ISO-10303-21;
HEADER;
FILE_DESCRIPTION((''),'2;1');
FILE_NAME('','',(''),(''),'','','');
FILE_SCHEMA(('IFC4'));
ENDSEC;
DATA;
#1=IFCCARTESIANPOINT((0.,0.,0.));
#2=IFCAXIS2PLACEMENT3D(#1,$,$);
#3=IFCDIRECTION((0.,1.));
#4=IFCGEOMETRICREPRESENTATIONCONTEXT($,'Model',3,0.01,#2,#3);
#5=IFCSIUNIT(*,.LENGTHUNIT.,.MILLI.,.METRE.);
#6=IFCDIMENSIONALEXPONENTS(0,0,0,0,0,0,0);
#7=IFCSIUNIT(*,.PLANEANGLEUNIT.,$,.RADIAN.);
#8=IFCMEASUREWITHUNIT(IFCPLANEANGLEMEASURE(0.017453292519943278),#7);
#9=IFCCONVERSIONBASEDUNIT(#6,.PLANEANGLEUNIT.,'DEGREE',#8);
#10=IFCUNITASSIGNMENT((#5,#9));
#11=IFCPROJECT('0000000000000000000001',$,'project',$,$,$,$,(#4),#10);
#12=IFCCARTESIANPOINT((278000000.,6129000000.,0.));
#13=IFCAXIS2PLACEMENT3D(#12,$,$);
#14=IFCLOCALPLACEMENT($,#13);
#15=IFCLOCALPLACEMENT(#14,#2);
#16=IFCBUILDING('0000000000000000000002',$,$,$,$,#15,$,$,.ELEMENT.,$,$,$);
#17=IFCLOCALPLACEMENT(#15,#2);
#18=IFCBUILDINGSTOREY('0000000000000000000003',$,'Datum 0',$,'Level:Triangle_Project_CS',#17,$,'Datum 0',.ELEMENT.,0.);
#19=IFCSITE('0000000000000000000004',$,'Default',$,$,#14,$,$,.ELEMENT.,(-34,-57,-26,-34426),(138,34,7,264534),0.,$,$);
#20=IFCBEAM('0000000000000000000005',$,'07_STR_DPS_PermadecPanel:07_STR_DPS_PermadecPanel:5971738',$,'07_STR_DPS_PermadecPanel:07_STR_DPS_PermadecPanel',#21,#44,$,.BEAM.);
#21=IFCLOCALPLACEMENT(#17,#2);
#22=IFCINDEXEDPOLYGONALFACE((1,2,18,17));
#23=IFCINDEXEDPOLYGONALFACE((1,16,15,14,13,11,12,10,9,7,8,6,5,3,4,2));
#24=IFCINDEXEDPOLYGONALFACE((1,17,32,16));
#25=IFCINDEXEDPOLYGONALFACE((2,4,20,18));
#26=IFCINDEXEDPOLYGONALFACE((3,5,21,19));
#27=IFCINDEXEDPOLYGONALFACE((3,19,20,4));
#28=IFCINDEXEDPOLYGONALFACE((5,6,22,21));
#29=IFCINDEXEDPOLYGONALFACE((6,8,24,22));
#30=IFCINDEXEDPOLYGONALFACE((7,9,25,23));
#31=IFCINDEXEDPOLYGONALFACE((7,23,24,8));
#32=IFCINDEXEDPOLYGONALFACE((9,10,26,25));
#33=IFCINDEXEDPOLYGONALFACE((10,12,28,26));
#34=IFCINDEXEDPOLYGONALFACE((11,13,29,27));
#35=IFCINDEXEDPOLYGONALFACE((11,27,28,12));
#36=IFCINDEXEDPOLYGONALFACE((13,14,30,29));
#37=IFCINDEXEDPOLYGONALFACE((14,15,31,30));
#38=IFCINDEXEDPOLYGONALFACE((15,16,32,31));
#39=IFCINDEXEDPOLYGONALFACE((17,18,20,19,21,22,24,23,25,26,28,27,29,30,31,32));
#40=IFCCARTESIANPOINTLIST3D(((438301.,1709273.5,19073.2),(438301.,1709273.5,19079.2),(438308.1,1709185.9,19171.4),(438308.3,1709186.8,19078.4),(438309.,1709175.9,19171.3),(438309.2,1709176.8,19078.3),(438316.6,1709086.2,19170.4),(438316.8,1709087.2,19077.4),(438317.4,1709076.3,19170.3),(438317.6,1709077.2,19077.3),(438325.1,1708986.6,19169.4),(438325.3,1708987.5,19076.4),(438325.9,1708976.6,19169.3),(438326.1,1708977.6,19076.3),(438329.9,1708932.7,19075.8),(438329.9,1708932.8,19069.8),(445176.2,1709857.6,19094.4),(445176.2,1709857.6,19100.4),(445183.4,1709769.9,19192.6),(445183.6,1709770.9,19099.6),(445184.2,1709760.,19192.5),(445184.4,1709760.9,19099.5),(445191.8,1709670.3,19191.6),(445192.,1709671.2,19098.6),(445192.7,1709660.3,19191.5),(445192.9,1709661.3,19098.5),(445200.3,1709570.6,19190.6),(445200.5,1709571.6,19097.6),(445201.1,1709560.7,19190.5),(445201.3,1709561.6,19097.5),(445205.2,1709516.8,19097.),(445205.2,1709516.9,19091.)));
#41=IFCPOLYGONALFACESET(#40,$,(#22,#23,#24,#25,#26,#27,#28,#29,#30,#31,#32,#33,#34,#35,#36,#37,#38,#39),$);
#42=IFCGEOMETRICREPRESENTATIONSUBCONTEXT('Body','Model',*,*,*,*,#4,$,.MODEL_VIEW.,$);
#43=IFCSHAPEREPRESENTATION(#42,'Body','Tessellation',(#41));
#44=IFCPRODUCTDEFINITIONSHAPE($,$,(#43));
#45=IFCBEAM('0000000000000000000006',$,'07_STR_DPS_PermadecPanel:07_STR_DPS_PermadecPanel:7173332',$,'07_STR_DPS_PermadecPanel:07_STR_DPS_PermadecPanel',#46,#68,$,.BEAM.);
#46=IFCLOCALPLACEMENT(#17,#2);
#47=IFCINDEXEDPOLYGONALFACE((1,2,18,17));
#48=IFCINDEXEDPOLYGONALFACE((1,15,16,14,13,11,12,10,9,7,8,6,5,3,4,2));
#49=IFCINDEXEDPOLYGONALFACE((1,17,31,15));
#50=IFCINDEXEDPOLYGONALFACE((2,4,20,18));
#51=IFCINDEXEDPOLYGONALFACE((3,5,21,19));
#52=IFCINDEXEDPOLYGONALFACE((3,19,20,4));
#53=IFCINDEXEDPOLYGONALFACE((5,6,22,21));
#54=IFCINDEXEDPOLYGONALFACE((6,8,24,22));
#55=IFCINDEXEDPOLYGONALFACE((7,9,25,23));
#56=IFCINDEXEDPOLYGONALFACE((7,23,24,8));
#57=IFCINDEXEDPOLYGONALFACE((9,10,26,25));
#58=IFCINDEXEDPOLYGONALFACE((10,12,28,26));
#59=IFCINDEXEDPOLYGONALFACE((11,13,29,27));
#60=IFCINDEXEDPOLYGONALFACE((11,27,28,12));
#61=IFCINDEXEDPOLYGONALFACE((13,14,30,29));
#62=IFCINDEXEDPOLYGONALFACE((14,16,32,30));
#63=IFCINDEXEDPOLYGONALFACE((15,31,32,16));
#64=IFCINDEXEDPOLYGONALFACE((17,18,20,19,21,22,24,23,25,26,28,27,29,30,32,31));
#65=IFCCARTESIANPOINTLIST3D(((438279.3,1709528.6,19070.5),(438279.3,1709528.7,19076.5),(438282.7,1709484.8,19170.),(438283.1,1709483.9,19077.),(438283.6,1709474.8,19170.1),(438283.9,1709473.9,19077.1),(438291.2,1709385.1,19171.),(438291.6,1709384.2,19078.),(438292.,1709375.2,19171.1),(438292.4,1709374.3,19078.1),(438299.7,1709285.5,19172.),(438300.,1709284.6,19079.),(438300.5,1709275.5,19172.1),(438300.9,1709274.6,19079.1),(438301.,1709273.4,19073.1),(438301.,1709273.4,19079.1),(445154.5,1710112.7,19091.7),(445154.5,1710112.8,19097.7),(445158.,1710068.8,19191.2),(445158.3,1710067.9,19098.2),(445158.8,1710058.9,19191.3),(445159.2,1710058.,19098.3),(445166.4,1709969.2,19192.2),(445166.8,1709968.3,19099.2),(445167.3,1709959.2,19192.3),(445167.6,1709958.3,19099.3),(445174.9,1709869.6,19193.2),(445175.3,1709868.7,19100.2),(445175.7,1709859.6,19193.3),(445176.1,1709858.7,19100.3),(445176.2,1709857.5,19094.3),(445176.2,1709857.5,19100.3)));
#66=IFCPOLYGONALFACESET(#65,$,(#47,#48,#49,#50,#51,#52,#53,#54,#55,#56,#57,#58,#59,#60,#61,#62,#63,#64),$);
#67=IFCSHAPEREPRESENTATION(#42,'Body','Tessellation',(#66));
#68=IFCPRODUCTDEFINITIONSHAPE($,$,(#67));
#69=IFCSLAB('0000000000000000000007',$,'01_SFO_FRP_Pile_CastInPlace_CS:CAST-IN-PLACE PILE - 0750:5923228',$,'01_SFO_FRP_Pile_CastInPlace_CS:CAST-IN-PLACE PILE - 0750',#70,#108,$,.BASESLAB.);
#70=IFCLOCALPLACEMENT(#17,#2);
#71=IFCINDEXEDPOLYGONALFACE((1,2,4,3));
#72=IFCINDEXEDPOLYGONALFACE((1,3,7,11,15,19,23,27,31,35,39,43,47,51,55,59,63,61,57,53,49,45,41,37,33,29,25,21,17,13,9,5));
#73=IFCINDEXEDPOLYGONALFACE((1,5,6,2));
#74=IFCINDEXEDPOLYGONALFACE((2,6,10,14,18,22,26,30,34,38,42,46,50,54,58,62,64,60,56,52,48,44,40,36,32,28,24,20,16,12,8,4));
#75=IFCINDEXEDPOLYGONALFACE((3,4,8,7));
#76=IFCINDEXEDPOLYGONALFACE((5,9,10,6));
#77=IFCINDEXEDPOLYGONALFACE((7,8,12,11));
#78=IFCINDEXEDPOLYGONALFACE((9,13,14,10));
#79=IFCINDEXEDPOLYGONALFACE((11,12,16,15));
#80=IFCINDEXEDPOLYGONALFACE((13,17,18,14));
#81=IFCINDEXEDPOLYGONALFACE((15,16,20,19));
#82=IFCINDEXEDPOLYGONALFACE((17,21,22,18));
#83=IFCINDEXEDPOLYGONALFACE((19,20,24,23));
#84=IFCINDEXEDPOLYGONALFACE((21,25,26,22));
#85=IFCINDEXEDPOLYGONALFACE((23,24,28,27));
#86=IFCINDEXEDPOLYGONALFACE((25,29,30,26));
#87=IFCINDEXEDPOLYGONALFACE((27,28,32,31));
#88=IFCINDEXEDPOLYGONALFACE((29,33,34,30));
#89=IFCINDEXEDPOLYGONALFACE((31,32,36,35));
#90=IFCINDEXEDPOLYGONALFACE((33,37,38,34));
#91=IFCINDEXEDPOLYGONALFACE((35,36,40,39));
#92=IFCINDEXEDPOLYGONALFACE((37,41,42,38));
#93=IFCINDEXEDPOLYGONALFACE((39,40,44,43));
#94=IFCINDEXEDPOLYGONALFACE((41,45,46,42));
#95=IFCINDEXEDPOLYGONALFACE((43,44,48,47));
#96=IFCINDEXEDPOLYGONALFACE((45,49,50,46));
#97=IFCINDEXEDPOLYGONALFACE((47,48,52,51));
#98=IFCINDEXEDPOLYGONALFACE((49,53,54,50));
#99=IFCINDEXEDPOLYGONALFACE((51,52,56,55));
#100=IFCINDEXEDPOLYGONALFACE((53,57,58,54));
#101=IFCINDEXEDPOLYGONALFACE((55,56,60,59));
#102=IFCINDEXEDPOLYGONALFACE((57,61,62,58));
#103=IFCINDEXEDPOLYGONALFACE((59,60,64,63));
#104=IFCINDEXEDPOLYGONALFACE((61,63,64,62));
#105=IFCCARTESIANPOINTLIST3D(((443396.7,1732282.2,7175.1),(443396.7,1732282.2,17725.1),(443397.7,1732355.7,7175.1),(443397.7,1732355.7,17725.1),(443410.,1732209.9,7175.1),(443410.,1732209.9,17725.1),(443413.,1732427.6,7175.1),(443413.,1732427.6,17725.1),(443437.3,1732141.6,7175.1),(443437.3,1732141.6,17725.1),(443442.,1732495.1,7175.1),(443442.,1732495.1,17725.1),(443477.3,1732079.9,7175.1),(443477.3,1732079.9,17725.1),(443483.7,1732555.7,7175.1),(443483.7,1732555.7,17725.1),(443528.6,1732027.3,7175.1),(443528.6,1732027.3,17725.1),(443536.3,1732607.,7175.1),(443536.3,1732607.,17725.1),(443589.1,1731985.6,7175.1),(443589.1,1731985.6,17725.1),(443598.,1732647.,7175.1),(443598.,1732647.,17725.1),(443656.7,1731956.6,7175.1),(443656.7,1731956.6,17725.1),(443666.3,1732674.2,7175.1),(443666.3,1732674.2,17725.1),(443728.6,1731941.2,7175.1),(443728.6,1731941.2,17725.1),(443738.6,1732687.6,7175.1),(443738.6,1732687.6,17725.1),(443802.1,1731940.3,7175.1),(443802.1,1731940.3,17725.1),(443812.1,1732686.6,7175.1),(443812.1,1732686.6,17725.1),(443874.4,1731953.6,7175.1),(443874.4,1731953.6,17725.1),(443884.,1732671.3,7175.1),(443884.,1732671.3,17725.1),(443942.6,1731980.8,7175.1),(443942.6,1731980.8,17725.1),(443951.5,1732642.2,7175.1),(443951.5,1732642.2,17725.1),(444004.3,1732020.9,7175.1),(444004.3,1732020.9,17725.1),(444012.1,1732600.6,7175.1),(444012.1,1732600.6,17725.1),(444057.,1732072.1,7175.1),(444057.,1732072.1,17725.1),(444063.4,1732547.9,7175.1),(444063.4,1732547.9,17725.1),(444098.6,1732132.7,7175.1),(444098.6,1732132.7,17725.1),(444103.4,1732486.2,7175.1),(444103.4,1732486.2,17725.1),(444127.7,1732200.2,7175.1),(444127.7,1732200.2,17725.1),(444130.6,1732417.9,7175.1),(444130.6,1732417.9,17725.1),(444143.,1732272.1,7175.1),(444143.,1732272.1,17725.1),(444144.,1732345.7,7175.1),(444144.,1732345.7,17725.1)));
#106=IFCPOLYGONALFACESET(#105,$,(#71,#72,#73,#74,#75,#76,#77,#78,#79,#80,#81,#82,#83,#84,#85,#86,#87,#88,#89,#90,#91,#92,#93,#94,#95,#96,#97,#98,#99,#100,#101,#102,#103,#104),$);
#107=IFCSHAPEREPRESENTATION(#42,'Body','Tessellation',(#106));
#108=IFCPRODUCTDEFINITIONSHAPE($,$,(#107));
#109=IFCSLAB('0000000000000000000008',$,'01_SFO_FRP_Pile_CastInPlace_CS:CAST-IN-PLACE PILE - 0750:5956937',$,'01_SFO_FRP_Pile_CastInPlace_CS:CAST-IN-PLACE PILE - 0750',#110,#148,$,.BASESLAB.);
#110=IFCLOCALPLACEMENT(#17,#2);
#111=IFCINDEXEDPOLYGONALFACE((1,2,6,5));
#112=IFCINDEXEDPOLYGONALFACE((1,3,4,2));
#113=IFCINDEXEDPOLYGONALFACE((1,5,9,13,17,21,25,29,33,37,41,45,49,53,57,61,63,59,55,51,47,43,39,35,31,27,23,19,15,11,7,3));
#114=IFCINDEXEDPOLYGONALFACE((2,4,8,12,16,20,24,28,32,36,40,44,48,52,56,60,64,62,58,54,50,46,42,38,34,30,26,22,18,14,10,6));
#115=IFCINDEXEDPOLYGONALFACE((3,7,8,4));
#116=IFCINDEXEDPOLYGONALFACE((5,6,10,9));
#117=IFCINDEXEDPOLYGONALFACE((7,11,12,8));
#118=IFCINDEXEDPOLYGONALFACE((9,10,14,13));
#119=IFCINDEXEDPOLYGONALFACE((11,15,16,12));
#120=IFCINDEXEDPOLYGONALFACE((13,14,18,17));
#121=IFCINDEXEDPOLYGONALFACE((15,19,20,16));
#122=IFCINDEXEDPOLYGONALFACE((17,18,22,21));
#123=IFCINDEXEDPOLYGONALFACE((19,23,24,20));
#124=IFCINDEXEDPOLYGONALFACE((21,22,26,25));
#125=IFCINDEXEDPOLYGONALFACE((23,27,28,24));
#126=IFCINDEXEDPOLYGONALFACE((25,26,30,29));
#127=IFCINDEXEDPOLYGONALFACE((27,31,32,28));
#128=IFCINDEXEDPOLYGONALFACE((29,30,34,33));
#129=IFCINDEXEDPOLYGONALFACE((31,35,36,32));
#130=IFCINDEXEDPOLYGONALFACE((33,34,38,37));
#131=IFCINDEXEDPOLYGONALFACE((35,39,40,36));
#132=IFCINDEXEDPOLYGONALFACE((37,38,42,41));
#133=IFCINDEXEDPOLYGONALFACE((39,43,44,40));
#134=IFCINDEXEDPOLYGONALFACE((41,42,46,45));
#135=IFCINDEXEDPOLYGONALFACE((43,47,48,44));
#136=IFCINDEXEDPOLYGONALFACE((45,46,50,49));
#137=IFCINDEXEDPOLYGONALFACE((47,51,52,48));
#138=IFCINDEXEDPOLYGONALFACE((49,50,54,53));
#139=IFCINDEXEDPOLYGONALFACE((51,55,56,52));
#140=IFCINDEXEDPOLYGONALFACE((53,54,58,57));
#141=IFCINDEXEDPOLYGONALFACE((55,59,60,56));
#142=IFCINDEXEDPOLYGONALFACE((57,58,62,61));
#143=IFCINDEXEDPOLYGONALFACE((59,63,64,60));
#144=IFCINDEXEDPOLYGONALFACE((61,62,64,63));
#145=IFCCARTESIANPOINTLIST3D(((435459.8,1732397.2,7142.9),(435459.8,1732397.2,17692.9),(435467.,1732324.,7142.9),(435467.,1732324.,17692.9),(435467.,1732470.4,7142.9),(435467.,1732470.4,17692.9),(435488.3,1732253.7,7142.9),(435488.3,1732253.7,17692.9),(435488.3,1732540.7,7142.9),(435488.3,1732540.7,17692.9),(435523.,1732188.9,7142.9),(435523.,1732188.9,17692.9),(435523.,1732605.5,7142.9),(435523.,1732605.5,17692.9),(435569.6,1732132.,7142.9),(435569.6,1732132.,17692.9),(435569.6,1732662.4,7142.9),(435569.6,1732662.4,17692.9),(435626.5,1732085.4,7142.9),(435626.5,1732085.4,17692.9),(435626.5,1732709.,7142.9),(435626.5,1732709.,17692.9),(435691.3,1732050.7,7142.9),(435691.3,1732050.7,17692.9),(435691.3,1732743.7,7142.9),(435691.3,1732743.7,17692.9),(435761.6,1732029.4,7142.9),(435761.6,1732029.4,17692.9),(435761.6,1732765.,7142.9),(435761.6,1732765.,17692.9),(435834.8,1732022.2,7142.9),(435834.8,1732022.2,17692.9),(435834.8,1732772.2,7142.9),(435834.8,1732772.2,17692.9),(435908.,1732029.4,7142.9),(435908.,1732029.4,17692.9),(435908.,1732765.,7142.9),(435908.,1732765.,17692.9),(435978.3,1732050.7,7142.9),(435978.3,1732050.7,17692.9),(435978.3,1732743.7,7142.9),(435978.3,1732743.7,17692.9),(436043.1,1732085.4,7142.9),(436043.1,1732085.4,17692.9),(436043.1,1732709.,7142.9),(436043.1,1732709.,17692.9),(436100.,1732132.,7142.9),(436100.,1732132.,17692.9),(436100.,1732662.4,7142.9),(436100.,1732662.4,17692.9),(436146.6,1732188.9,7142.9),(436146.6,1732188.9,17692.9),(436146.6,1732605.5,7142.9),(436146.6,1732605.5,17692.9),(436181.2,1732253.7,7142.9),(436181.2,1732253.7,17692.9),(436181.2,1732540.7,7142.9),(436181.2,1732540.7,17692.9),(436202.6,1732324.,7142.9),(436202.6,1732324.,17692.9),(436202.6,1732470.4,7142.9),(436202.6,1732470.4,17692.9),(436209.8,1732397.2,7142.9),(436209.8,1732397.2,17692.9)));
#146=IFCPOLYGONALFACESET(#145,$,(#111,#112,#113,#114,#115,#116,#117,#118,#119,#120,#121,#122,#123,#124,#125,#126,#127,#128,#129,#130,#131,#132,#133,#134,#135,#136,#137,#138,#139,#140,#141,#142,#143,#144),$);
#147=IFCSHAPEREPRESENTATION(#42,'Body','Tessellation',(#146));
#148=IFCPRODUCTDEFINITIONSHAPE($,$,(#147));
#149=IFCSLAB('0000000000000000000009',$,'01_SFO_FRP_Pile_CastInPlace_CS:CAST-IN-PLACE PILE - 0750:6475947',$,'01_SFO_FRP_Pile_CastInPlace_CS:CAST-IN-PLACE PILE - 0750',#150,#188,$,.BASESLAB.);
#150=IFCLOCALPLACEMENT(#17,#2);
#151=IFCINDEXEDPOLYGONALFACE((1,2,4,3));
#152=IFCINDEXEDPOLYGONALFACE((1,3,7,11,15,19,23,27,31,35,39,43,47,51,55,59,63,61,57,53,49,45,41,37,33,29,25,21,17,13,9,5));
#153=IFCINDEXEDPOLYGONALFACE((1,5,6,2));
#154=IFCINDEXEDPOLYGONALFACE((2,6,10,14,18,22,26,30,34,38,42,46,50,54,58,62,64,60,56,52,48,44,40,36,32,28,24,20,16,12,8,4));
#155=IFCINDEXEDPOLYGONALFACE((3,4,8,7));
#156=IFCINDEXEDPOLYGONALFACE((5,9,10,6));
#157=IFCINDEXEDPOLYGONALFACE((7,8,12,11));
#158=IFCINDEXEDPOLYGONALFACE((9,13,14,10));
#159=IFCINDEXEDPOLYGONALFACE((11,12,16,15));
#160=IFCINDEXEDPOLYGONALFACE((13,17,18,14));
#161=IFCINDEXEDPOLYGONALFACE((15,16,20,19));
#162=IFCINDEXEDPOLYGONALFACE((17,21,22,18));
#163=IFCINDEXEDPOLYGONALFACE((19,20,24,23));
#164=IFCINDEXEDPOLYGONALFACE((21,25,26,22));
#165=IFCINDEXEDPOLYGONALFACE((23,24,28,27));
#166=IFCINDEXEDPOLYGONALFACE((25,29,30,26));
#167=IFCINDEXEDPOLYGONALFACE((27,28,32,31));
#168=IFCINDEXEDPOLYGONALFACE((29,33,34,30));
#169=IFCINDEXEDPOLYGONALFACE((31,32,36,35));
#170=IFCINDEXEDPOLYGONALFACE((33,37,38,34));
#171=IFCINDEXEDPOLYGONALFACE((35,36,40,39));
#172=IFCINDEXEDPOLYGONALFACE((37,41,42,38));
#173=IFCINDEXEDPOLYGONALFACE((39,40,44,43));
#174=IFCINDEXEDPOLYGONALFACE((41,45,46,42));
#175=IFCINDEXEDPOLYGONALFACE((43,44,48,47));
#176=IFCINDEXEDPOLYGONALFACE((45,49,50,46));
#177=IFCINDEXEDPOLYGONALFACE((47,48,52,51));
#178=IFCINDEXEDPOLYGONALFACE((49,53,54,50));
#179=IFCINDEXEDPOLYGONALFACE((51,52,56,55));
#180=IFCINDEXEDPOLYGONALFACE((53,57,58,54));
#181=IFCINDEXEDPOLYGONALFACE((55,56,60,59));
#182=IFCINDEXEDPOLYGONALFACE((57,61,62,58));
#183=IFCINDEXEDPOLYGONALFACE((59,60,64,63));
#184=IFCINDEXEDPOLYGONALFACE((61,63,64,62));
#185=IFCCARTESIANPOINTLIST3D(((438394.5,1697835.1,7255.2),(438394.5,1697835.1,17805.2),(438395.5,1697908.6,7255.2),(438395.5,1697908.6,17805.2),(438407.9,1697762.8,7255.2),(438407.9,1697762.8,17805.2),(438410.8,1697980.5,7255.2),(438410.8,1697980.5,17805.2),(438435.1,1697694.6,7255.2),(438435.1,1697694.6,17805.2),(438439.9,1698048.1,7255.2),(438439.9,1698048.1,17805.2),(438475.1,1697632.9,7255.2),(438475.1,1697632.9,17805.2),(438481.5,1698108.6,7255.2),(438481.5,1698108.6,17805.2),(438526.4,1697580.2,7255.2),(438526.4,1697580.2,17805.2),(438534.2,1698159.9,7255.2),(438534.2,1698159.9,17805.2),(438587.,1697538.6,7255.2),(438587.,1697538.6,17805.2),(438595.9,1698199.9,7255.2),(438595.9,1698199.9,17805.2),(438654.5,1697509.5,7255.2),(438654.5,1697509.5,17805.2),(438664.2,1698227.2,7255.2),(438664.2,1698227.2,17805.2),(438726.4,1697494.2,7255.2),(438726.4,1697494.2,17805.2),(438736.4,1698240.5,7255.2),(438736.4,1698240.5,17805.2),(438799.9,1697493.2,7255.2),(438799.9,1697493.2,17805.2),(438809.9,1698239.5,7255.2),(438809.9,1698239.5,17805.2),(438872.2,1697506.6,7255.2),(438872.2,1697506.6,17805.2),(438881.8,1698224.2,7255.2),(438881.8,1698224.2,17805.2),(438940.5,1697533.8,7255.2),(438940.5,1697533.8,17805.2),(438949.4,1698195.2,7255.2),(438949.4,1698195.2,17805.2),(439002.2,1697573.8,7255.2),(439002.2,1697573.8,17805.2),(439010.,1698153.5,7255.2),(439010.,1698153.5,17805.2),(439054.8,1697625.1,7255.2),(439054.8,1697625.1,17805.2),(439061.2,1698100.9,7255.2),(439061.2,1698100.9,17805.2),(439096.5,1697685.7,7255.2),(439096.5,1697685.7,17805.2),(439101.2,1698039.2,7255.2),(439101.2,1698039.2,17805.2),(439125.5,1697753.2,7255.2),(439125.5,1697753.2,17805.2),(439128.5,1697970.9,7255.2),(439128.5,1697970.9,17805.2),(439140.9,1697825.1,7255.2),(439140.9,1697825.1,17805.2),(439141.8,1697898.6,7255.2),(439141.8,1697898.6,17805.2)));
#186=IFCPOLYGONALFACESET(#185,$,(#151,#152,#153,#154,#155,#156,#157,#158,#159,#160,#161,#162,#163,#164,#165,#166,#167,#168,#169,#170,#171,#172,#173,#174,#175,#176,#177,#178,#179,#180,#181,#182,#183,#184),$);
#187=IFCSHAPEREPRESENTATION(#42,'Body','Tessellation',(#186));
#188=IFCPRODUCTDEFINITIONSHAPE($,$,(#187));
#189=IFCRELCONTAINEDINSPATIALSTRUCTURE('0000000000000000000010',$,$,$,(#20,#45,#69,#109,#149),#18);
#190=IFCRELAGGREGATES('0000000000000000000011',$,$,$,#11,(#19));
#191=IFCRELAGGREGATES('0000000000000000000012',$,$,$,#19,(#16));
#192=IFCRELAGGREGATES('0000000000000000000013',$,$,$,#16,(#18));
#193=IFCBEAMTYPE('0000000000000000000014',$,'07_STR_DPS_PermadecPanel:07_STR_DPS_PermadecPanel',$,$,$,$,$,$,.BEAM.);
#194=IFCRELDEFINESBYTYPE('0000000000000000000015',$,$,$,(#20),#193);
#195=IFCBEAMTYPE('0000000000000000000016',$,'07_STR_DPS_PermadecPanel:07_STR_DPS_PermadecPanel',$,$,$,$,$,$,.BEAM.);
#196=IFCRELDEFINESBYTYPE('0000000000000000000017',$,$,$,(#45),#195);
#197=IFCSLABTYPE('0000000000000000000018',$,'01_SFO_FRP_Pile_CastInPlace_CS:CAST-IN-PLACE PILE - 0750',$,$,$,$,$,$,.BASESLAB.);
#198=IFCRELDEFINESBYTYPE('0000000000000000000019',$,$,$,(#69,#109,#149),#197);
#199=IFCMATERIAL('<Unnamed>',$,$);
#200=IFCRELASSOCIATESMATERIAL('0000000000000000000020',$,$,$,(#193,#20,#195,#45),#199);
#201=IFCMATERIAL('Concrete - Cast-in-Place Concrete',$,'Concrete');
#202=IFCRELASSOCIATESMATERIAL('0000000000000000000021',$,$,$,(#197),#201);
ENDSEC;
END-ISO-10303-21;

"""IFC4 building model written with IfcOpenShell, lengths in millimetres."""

from ifc_helpers import new_model, entity, si_unit, converted_unit, direction, frame, origin, place, context, subcontext, project, spatial, arc, indexed_curve, outline, extrude, source, transform, mapped, material, type_object, type_shapes, element, save


model = new_model("IFC4")

# Units and contexts
model_context = context("Model", 3, precision=0.01, world=origin(), true_north=direction((0.0, 1.0)))
body_context = subcontext(model_context, "Body", "Model", "MODEL_VIEW")
ifc_project = project(units=[si_unit("LENGTHUNIT", "METRE", prefix="MILLI"), converted_unit("PLANEANGLEUNIT", "DEGREE", entity("IfcPlaneAngleMeasure", 0.017453292519943278), si_unit("PLANEANGLEUNIT", "RADIAN"), dimensions=[0, 0, 0, 0, 0, 0, 0])], contexts=[model_context])

# Site, building, storey
site_placement = place(None, frame((278000000.0, 6129000000.0, 0.0)))
site = spatial("IfcSite", under=ifc_project, at=site_placement, Name="Default", CompositionType="ELEMENT", RefLatitude=(-34, -57, -26, -34426), RefLongitude=(138, 34, 7, 264534), RefElevation=0.0)
building_placement = place(site_placement, origin())
building = spatial("IfcBuilding", under=site, at=building_placement, CompositionType="ELEMENT")
storey_placement = place(building_placement, frame((0.0, 0.0, 0.0)))
storey = spatial("IfcBuildingStorey", under=building, at=storey_placement, Name="Datum 0", ObjectType="Level:Triangle_Project_CS", LongName="Datum 0", CompositionType="ELEMENT", Elevation=0.0)

# Beams
ifc_material_1 = material(Name="<Unnamed>")
beam_type_1 = type_object("IfcBeamType", Name="07_STR_DPS_PermadecPanel:07_STR_DPS_PermadecPanel", PredefinedType="BEAM", material=ifc_material_1)
shared_shape_1 = source(origin(), body_context, "Body", "SweptSolid", [
    extrude(outline(indexed_curve([(-110.3, -58.9), (-100.3, -58.9), (-100.3, 34.1), (-10.3, 34.1), (-10.3, -58.9), (-0.3, -58.9), (-0.3, 34.1), (89.7, 34.1), (89.7, -58.9), (99.7, -58.9), (99.7, 34.1), (186.8, 34.1), (186.7, 40.1), (-155.3, 40.1), (-155.3, 34.1), (-110.3, 34.1), (-110.3, -58.9)], self_intersect=False)), frame((445191.9, 1709671.1, 19132.7), z_axis=(-0.996406, -0.084646, -0.003073), x_axis=(-0.084673, 0.996359, 0.009987)), (0.0, 0.0, 1.0), 6900.0),
])
type_shapes(beam_type_1, [shared_shape_1])
beam_1_placement = place(storey_placement, frame((0.0, 0.0, 0.0)))
element("IfcBeam", 1, at=beam_1_placement, inside=storey, type_object=beam_type_1, material=ifc_material_1, Name="07_STR_DPS_PermadecPanel:07_STR_DPS_PermadecPanel:5971738", ObjectType="07_STR_DPS_PermadecPanel:07_STR_DPS_PermadecPanel", PredefinedType="BEAM", context=body_context, shape_type="MappedRepresentation", body=[
    mapped(shared_shape_1, transform((0.0, 0.0, 0.0), scale=1.0)),
])
beam_type_2 = type_object("IfcBeamType", Name="07_STR_DPS_PermadecPanel:07_STR_DPS_PermadecPanel", PredefinedType="BEAM", material=ifc_material_1)
shared_shape_2 = source(origin(), body_context, "Body", "SweptSolid", [
    extrude(outline(indexed_curve([(-34.1, -110.5), (58.9, -110.5), (58.9, -100.5), (-34.1, -100.5), (-34.1, -10.5), (58.9, -10.5), (58.9, -0.5), (-34.1, -0.5), (-34.1, 89.5), (58.9, 89.5), (58.9, 99.5), (-34.1, 99.5), (-34.1, 144.5), (-40.1, 144.5), (-40.1, -111.6), (-34.1, -111.7), (-34.1, -110.5)], self_intersect=False)), frame((445166.6, 1709969.1, 19133.3), z_axis=(-0.996406, -0.084646, -0.003073), x_axis=(-0.003904, 0.009657, 0.999946)), (0.0, 0.0, 1.0), 6900.0),
])
type_shapes(beam_type_2, [shared_shape_2])
beam_2_placement = place(storey_placement, frame((0.0, 0.0, 0.0)))
element("IfcBeam", 2, at=beam_2_placement, inside=storey, type_object=beam_type_2, material=ifc_material_1, Name="07_STR_DPS_PermadecPanel:07_STR_DPS_PermadecPanel:7173332", ObjectType="07_STR_DPS_PermadecPanel:07_STR_DPS_PermadecPanel", PredefinedType="BEAM", context=body_context, shape_type="MappedRepresentation", body=[
    mapped(shared_shape_2, transform((0.0, 0.0, 0.0), scale=1.0)),
])

# Slabs
ifc_material_2 = material(Name="Concrete - Cast-in-Place Concrete", Category="Concrete")
slab_type_1 = type_object("IfcSlabType", Name="01_SFO_FRP_Pile_CastInPlace_CS:CAST-IN-PLACE PILE - 0750", PredefinedType="BASESLAB", material=ifc_material_2)
slab_1_placement = place(storey_placement, origin())
element("IfcSlab", 3, at=slab_1_placement, inside=storey, type_object=slab_type_1, Name="01_SFO_FRP_Pile_CastInPlace_CS:CAST-IN-PLACE PILE - 0750:5923228", ObjectType="01_SFO_FRP_Pile_CastInPlace_CS:CAST-IN-PLACE PILE - 0750", PredefinedType="BASESLAB", context=body_context, shape_type="SweptSolid", body=[
    extrude(outline(indexed_curve([(-375.0, 0.0), (0.0, -375.0), (375.0, 0.0), (0.0, 375.0)], segments=[arc(1, 2, 3), arc(3, 4, 1)], self_intersect=False)), frame((443770.3, 1732313.9, 7175.1), z_axis=(0.0, 0.0, 1.0), x_axis=(0.996411, 0.084646, 0.0)), (0.0, 0.0, 1.0), 10550.0),
])
slab_2_placement = place(storey_placement, origin())
element("IfcSlab", 4, at=slab_2_placement, inside=storey, type_object=slab_type_1, Name="01_SFO_FRP_Pile_CastInPlace_CS:CAST-IN-PLACE PILE - 0750:5956937", ObjectType="01_SFO_FRP_Pile_CastInPlace_CS:CAST-IN-PLACE PILE - 0750", PredefinedType="BASESLAB", context=body_context, shape_type="SweptSolid", body=[
    extrude(outline(indexed_curve([(-375.0, 0.0), (0.0, -375.0), (375.0, 0.0), (0.0, 375.0)], segments=[arc(1, 2, 3), arc(3, 4, 1)], self_intersect=False)), frame((435834.8, 1732397.2, 7142.9), z_axis=(0.0, 0.0, 1.0), x_axis=(-1.0, 0.0, 0.0)), (0.0, 0.0, 1.0), 10550.0),
])
slab_3_placement = place(storey_placement, origin())
element("IfcSlab", 5, at=slab_3_placement, inside=storey, type_object=slab_type_1, Name="01_SFO_FRP_Pile_CastInPlace_CS:CAST-IN-PLACE PILE - 0750:6475947", ObjectType="01_SFO_FRP_Pile_CastInPlace_CS:CAST-IN-PLACE PILE - 0750", PredefinedType="BASESLAB", context=body_context, shape_type="SweptSolid", body=[
    extrude(outline(indexed_curve([(-375.0, 0.0), (0.0, -375.0), (375.0, 0.0), (0.0, 375.0)], segments=[arc(1, 2, 3), arc(3, 4, 1)], self_intersect=False)), frame((438768.2, 1697866.9, 7255.2), z_axis=(0.0, 0.0, 1.0), x_axis=(-0.996411, -0.084646, 0.0)), (0.0, 0.0, 1.0), 10550.0),
])

save(model, "model.ifc")
